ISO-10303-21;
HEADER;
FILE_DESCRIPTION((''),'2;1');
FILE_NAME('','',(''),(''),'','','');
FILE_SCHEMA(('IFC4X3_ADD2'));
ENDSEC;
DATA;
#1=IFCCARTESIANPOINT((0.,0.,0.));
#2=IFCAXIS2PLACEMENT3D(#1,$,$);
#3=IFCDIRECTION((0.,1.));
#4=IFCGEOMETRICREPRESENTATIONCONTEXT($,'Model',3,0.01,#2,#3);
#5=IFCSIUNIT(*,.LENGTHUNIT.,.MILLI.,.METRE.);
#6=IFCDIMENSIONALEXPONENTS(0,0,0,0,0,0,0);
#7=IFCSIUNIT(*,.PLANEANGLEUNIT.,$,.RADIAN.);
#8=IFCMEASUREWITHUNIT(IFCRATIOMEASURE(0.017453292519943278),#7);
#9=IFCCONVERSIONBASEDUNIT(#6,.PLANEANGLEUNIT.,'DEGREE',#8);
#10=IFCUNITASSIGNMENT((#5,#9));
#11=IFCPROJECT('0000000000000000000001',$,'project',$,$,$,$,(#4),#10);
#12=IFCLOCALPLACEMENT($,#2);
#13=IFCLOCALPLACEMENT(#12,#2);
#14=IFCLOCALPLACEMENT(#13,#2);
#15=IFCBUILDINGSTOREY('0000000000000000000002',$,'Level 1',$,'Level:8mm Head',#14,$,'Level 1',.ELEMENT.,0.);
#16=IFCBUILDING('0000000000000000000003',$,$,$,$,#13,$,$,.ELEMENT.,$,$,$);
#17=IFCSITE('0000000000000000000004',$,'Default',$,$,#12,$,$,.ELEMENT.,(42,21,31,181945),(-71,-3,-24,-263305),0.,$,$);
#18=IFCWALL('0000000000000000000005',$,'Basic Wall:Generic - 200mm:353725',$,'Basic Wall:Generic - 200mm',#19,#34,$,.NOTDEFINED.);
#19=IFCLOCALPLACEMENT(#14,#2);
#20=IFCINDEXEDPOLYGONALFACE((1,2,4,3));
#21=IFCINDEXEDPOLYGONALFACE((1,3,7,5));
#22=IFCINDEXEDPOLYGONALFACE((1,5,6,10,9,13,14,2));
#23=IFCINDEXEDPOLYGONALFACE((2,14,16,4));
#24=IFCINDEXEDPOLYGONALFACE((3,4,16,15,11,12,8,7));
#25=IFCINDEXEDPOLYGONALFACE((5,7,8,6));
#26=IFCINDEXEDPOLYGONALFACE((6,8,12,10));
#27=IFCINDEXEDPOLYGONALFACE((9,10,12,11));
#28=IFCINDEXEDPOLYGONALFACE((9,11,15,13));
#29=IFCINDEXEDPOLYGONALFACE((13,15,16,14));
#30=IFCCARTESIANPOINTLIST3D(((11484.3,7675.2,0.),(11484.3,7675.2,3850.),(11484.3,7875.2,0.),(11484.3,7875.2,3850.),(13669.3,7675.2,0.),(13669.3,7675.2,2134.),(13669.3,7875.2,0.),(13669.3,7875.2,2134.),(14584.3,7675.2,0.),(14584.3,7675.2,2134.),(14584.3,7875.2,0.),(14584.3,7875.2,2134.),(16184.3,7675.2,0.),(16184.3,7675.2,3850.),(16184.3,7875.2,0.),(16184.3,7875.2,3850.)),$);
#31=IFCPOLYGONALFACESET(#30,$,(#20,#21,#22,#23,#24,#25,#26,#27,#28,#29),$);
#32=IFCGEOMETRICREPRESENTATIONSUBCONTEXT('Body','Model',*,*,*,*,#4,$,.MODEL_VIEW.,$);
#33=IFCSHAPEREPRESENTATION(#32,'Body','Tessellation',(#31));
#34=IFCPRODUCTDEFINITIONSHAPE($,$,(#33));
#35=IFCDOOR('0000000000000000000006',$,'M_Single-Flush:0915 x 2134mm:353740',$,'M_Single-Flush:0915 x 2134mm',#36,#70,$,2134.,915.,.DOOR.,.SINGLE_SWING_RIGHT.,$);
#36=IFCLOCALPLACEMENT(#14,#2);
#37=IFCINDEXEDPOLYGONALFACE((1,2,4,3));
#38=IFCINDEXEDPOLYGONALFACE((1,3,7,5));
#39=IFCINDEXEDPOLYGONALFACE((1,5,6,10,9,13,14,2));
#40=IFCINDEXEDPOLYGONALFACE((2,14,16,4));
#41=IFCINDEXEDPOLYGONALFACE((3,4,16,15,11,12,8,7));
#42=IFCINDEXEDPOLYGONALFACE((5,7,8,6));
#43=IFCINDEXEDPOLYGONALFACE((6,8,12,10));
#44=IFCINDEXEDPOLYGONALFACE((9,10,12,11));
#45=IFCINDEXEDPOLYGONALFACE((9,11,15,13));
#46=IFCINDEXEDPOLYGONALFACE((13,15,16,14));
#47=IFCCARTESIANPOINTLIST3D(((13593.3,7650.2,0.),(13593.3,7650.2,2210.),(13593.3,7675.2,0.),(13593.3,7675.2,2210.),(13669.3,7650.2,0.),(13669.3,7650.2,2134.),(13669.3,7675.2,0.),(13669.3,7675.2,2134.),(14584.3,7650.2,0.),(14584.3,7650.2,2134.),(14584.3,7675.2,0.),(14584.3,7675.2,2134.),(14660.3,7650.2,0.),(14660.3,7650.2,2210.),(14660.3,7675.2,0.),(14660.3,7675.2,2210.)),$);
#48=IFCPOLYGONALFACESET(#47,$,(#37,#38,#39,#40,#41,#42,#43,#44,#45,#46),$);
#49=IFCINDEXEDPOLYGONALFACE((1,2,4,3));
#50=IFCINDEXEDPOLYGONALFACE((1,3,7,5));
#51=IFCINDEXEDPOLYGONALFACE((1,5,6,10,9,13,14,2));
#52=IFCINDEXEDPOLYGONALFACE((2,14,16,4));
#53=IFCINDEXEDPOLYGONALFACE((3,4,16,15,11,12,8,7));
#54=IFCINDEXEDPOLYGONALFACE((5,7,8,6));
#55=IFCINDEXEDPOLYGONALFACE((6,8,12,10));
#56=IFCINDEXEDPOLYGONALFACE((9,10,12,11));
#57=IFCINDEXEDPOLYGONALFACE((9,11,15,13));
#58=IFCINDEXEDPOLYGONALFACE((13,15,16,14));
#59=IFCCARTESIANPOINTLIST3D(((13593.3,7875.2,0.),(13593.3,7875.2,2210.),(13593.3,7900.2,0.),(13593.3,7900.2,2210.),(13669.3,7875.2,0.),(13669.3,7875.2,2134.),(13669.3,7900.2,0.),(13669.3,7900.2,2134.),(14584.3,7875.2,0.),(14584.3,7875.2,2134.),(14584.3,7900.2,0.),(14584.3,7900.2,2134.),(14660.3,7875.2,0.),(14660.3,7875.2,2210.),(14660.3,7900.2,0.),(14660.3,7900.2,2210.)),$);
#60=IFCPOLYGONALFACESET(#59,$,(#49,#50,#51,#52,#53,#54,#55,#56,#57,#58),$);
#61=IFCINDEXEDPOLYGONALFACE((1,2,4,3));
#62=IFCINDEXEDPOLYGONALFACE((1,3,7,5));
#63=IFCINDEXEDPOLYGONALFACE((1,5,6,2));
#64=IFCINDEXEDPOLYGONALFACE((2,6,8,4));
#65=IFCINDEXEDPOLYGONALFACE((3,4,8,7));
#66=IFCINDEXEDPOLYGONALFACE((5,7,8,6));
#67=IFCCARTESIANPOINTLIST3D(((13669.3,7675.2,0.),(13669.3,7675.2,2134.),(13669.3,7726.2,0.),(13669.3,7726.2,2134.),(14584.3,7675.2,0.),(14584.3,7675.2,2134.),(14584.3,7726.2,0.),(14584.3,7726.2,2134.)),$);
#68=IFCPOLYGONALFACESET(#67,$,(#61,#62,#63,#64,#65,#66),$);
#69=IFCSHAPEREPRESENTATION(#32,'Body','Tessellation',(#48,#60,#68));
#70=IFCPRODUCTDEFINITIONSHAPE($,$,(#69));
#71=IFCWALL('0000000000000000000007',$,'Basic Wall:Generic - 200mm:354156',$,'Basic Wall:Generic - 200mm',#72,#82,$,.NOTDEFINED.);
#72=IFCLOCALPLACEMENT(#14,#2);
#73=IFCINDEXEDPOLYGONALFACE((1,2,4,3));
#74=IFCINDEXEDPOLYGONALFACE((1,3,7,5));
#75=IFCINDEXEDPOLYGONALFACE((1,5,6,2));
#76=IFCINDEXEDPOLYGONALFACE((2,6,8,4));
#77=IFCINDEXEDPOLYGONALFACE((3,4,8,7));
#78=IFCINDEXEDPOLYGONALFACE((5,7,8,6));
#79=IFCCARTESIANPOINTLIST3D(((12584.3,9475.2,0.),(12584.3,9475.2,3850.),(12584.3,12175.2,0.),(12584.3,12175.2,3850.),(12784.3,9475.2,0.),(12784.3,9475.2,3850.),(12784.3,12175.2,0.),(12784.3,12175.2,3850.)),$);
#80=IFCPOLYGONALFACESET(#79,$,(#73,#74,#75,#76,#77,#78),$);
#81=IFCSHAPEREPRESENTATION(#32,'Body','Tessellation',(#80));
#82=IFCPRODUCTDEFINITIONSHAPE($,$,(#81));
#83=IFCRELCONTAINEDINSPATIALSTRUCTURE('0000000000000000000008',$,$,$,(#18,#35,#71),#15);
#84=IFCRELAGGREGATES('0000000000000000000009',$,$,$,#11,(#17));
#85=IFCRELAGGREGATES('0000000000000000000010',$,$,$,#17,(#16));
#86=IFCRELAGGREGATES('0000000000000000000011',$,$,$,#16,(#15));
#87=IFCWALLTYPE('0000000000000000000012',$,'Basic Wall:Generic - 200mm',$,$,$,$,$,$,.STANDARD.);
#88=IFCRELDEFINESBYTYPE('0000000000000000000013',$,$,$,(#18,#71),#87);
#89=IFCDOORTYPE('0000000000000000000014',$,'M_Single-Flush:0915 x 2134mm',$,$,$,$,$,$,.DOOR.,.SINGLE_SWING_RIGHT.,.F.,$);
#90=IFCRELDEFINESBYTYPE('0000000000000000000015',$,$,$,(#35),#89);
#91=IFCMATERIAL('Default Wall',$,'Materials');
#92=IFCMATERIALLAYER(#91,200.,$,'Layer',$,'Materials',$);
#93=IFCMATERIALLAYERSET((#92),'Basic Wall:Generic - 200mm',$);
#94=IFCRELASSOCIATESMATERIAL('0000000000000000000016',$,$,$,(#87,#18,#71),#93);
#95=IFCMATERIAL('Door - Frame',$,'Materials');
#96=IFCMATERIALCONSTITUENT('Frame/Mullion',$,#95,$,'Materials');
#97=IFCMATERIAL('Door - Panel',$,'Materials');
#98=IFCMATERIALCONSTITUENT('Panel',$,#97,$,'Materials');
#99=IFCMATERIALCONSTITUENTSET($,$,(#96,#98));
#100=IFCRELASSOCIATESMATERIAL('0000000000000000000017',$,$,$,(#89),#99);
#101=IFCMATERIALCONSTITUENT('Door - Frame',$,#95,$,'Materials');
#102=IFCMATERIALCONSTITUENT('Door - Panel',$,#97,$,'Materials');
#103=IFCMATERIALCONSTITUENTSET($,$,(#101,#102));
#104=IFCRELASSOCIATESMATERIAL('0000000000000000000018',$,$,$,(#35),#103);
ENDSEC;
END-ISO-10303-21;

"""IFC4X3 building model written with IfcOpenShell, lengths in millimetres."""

from ifc_helpers import new_model, entity, si_unit, converted_unit, direction, frame, frame_2d, origin, place, context, subcontext, project, spatial, polyline, rectangle, outline, extrude, clip, bounded_halfspace, source, transform, mapped, material, layer, layer_set, constituent, constituent_set, type_object, type_shapes, element, fill, save


model = new_model("IFC4X3")

# Units and contexts
model_context = context("Model", 3, precision=0.01, world=origin(), true_north=direction((0.0, 1.0)))
body_context = subcontext(model_context, "Body", "Model", "MODEL_VIEW")
ifc_project = project(units=[si_unit("LENGTHUNIT", "METRE", prefix="MILLI"), converted_unit("PLANEANGLEUNIT", "DEGREE", entity("IfcRatioMeasure", 0.017453292519943278), si_unit("PLANEANGLEUNIT", "RADIAN"), dimensions=[0, 0, 0, 0, 0, 0, 0])], contexts=[model_context])

# Site, building, storey
site_placement = place(None, origin())
site = spatial("IfcSite", under=ifc_project, at=site_placement, Name="Default", CompositionType="ELEMENT", RefLatitude=(42, 21, 31, 181945), RefLongitude=(-71, -3, -24, -263305), RefElevation=0.0)
building_placement = place(site_placement, origin())
building = spatial("IfcBuilding", under=site, at=building_placement, CompositionType="ELEMENT")
storey_placement = place(building_placement, origin())
storey = spatial("IfcBuildingStorey", under=building, at=storey_placement, Name="Level 1", ObjectType="Level:8mm Head", LongName="Level 1", CompositionType="ELEMENT", Elevation=0.0)

# Shared definitions
ifc_material_1 = material(Name="Default Wall", Category="Materials")
ifc_layer_1 = layer(ifc_material_1, 200.0, Name="Layer", Category="Materials")
ifc_layer_set_1 = layer_set([ifc_layer_1], Name="Basic Wall:Generic - 200mm")
wall_type = type_object("IfcWallType", Name="Basic Wall:Generic - 200mm", PredefinedType="STANDARD", material=ifc_layer_set_1)

# Shared definitions
ifc_material_2 = material(Name="Door - Frame", Category="Materials")
ifc_material_3 = material(Name="Door - Panel", Category="Materials")
ifc_constituent_1 = constituent(ifc_material_2, Name="Frame/Mullion", Category="Materials")
ifc_constituent_2 = constituent(ifc_material_3, Name="Panel", Category="Materials")
ifc_constituent_set_1 = constituent_set(constituents=[ifc_constituent_1, ifc_constituent_2])
door_type = type_object("IfcDoorType", Name="M_Single-Flush:0915 x 2134mm", OperationType="SINGLE_SWING_RIGHT", ParameterTakesPrecedence=False, PredefinedType="DOOR", material=ifc_constituent_set_1)
shared_shape = source(origin(), body_context, "Body", "SweptSolid", [
    extrude(outline(polyline([(-533.5, -1124.0), (533.5, -1124.0), (533.5, 1086.0), (457.5, 1086.0), (457.5, -1048.0), (-457.5, -1048.0), (-457.5, 1086.0), (-533.5, 1086.0), (-533.5, -1124.0)])), frame((457.5, 200.0, 1086.0), z_axis=(0.0, 1.0, 0.0), x_axis=(1.0, 0.0, 0.0)), (0.0, 0.0, 1.0), 25.0),
    extrude(outline(polyline([(-1124.0, -533.5), (1086.0, -533.5), (1086.0, -457.5), (-1048.0, -457.5), (-1048.0, 457.5), (1086.0, 457.5), (1086.0, 533.5), (-1124.0, 533.5), (-1124.0, -533.5)])), frame((457.5, -25.0, 1086.0), z_axis=(0.0, 1.0, 0.0), x_axis=(0.0, 0.0, -1.0)), (0.0, 0.0, 1.0), 25.0),
    extrude(rectangle(XDim=51.0, YDim=915.0, at=frame_2d((0.0, 0.0), x_axis=(1.0, 0.0))), frame((457.5, 174.5, 0.0), z_axis=(0.0, 0.0, 1.0), x_axis=(0.0, 1.0, 0.0)), (0.0, 0.0, 1.0), 2134.0),
])
type_shapes(door_type, [shared_shape])

# Wall, opening, door
wall_1_placement = place(storey_placement, frame((11484.3, 7775.2, 0.0)))
wall_1 = element("IfcWall", 1, at=wall_1_placement, inside=storey, type_object=wall_type, material=ifc_layer_set_1, Name="Basic Wall:Generic - 200mm:353725", ObjectType="Basic Wall:Generic - 200mm", PredefinedType="NOTDEFINED", context=body_context, shape_type="Clipping", body=[
    clip(extrude(rectangle(XDim=4700.0, YDim=200.0, at=frame_2d((2350.0, 0.0), x_axis=(1.0, 0.0))), origin(), (0.0, 0.0, 1.0), 3850.0), bounded_halfspace(frame((0.0, -100.0, 3850.0), z_axis=(0.0, 0.0, -1.0), x_axis=(1.0, 0.0, 0.0)), True, frame((0.0, -100.0, 3850.0)), polyline([(0.0, 0.0), (4700.0, 0.0), (4700.0, 200.0), (0.0, 200.0), (0.0, 0.0)]))),
])
opening_1_placement = place(wall_1_placement, frame((3100.0, 100.0, 0.0)))
opening_1 = element("IfcOpeningElement", 2, at=opening_1_placement, cuts=wall_1, PredefinedType="OPENING", context=body_context, shape_type="SweptSolid", body=[
    extrude(rectangle(XDim=915.0, YDim=2134.0, at=frame_2d((1067.0, 457.5), x_axis=(0.0, 1.0))), frame((0.0, 0.0, 0.0), z_axis=(0.0, -1.0, 0.0), x_axis=(0.0, 0.0, 1.0)), (0.0, 0.0, 1.0), 200.0),
])
ifc_constituent_3 = constituent(ifc_material_2, Name="Door - Frame", Category="Materials")
ifc_constituent_4 = constituent(ifc_material_3, Name="Door - Panel", Category="Materials")
ifc_constituent_set_2 = constituent_set(constituents=[ifc_constituent_3, ifc_constituent_4])
door_1_placement = place(opening_1_placement, frame((0.0, 0.0, 0.0), z_axis=(0.0, 0.0, 1.0), x_axis=(-1.0, 0.0, 0.0)))
door_1 = element("IfcDoor", 3, at=door_1_placement, inside=storey, type_object=door_type, material=ifc_constituent_set_2, Name="M_Single-Flush:0915 x 2134mm:353740", ObjectType="M_Single-Flush:0915 x 2134mm", OperationType="SINGLE_SWING_RIGHT", OverallHeight=2134.0, OverallWidth=915.0, PredefinedType="DOOR", context=body_context, shape_type="MappedRepresentation", body=[
    mapped(shared_shape, transform((0.0, 0.0, 0.0), scale=1.0)),
])
fill(opening_1, door_1)

# Wall
wall_2_placement = place(storey_placement, frame((12684.3, 12175.2, 0.0), z_axis=(0.0, 0.0, 1.0), x_axis=(0.0, -1.0, 0.0)))
element("IfcWall", 4, at=wall_2_placement, inside=storey, type_object=wall_type, material=ifc_layer_set_1, Name="Basic Wall:Generic - 200mm:354156", ObjectType="Basic Wall:Generic - 200mm", PredefinedType="NOTDEFINED", context=body_context, shape_type="Clipping", body=[
    clip(extrude(rectangle(XDim=2700.0, YDim=200.0, at=frame_2d((1350.0, 0.0), x_axis=(-1.0, 0.0))), origin(), (0.0, 0.0, 1.0), 3850.0), bounded_halfspace(frame((0.0, -100.0, 3850.0), z_axis=(0.0, 0.0, -1.0), x_axis=(0.0, 1.0, 0.0)), True, frame((0.0, -100.0, 3850.0)), polyline([(0.0, 0.0), (2700.0, 0.0), (2700.0, 200.0), (0.0, 200.0), (0.0, 0.0)]))),
])

save(model, "model.ifc")
